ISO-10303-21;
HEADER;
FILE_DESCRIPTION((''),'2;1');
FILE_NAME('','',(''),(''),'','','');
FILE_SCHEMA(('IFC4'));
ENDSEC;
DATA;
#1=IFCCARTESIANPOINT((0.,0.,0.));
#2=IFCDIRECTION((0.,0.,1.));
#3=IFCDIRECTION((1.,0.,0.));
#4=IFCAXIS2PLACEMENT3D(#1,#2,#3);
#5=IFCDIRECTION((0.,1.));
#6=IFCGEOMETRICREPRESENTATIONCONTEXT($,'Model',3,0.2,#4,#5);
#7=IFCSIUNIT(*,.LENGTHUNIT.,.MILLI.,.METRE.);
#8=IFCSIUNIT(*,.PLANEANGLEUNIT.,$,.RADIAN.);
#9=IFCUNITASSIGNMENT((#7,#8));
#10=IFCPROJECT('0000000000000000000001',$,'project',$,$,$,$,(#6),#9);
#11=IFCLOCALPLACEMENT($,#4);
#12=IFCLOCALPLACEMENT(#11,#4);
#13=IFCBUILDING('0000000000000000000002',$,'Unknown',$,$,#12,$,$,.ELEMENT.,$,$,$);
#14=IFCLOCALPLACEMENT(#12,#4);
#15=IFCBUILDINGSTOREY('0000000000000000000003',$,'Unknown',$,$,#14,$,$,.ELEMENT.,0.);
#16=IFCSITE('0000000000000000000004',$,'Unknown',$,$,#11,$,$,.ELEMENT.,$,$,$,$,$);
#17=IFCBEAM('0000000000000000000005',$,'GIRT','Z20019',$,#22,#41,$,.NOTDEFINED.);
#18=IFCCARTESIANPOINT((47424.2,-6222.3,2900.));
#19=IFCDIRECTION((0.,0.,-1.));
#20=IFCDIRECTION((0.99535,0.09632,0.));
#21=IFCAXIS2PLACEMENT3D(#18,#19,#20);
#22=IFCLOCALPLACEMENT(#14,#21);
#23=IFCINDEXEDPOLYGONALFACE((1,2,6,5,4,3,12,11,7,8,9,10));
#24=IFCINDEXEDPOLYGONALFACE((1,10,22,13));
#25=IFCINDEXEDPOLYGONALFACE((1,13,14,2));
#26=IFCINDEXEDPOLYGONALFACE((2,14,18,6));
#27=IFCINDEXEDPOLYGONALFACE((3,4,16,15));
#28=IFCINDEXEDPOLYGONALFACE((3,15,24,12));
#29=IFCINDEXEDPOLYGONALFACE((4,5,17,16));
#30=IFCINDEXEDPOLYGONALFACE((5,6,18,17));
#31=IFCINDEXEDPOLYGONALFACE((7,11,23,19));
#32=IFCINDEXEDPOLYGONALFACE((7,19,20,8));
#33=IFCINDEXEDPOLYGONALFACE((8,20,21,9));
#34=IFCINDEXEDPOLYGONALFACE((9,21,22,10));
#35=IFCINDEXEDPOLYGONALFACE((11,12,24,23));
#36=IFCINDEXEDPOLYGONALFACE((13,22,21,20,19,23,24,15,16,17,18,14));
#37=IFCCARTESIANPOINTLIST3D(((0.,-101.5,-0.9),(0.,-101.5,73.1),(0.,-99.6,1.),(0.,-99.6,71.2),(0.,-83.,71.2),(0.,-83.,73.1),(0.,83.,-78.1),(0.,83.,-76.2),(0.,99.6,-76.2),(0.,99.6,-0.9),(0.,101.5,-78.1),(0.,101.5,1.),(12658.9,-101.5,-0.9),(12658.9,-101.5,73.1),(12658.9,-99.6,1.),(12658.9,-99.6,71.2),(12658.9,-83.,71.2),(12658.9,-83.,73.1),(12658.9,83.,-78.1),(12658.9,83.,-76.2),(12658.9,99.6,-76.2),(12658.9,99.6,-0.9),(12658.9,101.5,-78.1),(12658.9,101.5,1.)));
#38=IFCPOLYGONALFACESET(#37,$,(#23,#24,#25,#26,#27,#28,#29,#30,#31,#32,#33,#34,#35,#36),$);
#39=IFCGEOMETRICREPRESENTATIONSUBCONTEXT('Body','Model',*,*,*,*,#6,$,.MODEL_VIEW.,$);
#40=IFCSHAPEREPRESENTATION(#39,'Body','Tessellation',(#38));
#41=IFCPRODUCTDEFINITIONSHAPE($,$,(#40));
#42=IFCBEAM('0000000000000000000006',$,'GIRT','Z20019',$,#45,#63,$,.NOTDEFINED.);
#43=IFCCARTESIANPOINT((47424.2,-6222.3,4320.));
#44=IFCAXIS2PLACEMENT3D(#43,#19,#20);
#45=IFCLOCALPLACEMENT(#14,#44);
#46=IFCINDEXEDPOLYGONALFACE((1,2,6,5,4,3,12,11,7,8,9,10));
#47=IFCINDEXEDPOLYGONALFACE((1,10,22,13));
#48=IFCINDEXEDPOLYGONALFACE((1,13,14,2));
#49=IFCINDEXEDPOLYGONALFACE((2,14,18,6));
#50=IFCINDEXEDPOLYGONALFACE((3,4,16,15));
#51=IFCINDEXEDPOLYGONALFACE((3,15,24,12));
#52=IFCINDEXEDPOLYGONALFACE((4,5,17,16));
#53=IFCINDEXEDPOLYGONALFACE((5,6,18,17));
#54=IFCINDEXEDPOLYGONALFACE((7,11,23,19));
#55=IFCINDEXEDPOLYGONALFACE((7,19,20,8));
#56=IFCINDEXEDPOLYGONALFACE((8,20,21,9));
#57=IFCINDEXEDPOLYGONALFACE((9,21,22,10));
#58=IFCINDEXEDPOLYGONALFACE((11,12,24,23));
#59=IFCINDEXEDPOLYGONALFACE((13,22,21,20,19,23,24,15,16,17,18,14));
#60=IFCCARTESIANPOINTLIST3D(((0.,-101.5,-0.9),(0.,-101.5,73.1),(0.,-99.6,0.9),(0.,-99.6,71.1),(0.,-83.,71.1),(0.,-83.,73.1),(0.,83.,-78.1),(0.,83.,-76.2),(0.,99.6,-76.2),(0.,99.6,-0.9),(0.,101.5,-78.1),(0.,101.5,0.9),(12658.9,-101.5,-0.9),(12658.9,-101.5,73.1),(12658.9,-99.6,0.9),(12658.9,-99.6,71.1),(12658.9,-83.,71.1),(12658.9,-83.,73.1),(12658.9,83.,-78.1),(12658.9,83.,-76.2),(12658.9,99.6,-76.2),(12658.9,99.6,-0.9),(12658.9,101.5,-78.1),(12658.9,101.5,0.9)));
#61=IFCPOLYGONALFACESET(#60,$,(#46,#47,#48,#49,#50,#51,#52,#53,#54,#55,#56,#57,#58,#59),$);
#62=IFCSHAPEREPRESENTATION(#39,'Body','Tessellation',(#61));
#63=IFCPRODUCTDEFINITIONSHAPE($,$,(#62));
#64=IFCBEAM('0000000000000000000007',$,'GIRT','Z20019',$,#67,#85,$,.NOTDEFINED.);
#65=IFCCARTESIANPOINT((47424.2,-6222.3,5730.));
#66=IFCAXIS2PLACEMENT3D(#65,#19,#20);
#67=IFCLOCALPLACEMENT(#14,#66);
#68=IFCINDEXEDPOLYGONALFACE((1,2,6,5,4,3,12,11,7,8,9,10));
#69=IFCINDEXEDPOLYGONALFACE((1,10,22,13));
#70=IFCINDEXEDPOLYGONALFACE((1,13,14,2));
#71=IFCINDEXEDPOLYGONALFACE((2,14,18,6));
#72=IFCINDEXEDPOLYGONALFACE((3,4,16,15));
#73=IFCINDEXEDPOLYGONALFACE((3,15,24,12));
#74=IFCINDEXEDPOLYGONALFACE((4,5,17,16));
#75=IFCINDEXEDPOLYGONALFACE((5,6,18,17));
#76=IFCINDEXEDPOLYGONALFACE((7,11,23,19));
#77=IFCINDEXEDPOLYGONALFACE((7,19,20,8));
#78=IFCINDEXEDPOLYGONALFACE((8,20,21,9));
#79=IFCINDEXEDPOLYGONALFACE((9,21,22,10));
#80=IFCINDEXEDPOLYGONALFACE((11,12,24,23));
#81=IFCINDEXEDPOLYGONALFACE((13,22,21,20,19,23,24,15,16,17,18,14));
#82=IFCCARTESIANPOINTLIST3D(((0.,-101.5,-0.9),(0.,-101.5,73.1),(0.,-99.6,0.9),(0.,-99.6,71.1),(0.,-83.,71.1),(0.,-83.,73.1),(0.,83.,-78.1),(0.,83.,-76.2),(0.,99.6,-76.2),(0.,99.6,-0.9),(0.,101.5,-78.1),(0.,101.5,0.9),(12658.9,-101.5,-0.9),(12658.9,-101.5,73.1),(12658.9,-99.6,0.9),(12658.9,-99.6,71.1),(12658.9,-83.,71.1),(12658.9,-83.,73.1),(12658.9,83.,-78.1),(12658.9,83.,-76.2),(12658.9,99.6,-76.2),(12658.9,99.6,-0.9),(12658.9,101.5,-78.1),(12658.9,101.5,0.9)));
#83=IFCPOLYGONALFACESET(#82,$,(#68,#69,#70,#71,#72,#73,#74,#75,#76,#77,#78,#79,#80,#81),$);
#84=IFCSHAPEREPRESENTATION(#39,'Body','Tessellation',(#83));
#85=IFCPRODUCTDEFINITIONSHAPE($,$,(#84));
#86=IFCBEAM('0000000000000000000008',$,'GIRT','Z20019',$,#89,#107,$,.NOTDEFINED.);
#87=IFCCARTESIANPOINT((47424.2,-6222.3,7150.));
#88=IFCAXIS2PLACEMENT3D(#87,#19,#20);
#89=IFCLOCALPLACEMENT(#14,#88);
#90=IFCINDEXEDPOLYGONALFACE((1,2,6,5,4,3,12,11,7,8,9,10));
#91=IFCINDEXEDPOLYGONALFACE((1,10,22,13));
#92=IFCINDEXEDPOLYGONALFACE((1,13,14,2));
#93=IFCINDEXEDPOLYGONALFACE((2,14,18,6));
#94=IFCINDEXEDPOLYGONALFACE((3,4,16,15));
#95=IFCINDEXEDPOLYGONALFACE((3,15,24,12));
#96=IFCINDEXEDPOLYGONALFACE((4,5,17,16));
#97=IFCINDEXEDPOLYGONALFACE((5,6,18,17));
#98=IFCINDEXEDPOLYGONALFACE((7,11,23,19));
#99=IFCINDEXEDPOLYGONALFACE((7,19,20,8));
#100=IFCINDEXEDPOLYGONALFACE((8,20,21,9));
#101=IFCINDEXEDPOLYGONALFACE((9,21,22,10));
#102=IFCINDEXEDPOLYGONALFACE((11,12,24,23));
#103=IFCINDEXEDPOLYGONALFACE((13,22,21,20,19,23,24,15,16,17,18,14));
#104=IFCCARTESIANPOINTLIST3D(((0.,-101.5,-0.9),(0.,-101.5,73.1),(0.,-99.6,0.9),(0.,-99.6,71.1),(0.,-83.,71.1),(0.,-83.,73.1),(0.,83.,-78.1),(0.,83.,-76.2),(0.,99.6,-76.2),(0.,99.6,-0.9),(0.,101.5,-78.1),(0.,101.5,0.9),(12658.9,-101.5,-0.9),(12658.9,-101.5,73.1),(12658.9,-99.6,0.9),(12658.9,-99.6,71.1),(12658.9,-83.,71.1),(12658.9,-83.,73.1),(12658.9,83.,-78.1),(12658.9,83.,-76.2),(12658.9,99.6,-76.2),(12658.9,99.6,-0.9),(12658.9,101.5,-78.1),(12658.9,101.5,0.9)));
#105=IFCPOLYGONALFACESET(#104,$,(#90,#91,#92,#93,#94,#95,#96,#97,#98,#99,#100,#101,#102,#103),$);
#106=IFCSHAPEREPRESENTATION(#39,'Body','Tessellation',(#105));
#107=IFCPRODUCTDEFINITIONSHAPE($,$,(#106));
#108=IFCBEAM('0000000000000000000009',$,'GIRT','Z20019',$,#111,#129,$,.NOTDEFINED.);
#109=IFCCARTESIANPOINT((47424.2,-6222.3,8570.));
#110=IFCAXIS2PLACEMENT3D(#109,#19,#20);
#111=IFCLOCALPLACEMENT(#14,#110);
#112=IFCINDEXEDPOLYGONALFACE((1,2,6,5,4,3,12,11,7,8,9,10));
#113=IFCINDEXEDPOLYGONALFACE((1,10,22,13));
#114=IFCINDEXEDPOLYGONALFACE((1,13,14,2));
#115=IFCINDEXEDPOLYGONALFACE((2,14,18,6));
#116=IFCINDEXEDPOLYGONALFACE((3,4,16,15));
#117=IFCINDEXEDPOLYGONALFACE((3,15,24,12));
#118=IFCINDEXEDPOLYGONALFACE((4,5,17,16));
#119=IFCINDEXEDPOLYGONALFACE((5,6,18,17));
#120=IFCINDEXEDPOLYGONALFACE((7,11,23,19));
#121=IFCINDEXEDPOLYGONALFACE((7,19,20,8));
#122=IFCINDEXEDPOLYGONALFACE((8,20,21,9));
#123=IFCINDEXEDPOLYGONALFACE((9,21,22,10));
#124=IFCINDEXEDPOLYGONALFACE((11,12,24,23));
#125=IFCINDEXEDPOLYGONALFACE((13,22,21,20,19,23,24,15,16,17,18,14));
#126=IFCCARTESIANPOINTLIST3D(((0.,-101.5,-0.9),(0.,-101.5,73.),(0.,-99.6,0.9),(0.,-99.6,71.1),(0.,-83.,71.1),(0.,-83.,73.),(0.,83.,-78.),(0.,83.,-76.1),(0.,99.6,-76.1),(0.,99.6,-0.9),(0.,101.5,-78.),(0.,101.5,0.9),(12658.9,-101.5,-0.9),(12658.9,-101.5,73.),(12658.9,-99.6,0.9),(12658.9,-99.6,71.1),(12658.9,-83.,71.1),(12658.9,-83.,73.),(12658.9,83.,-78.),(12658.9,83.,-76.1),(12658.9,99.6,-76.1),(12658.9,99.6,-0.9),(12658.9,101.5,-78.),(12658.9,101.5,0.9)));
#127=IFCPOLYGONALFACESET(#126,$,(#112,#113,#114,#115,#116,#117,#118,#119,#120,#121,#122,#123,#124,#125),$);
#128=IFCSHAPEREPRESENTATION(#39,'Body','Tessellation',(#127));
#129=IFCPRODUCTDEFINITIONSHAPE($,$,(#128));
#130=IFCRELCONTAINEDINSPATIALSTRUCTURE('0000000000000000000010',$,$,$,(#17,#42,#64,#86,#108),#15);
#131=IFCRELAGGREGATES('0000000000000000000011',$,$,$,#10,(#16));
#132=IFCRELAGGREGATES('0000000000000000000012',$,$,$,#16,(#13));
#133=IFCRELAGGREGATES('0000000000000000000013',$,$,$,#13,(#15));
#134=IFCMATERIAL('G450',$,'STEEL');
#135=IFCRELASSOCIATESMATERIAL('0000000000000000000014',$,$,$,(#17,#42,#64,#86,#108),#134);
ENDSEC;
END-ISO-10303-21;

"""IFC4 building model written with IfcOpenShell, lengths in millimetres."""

from ifc_helpers import new_model, si_unit, direction, frame, origin_with_axes, place, context, subcontext, project, spatial, line, indexed_curve, outline, extrude, material, element, save


model = new_model("IFC4")

# Units and contexts
model_context = context("Model", 3, precision=0.2, world=origin_with_axes(), true_north=direction((0.0, 1.0)))
body_context = subcontext(model_context, "Body", "Model", "MODEL_VIEW")
ifc_project = project(units=[si_unit("LENGTHUNIT", "METRE", prefix="MILLI"), si_unit("PLANEANGLEUNIT", "RADIAN")], contexts=[model_context])

# Site, building, storey
site_placement = place(None, origin_with_axes())
site = spatial("IfcSite", under=ifc_project, at=site_placement, Name="Unknown", CompositionType="ELEMENT")
building_placement = place(site_placement, origin_with_axes())
building = spatial("IfcBuilding", under=site, at=building_placement, Name="Unknown", CompositionType="ELEMENT")
storey_placement = place(building_placement, origin_with_axes())
storey = spatial("IfcBuildingStorey", under=building, at=storey_placement, Name="Unknown", CompositionType="ELEMENT", Elevation=0.0)

# Shared definitions
ifc_material_1 = material(Name="G450", Category="STEEL")

# Beams
for number, where, z_axis, x_axis, name in (
    (1, (47424.2, -6222.3, 2900.0), (0.0, 0.0, -1.0), (0.99535, 0.09632, 0.0), "GIRT"),
    (2, (47424.2, -6222.3, 4320.0), (0.0, 0.0, -1.0), (0.99535, 0.09632, 0.0), "GIRT"),
    (3, (47424.2, -6222.3, 5730.0), (0.0, 0.0, -1.0), (0.99535, 0.09632, 0.0), "GIRT"),
    (4, (47424.2, -6222.3, 7150.0), (0.0, 0.0, -1.0), (0.99535, 0.09632, 0.0), "GIRT"),
    (5, (47424.2, -6222.3, 8570.0), (0.0, 0.0, -1.0), (0.99535, 0.09632, 0.0), "GIRT"),
):
    element("IfcBeam", number, at=place(storey_placement, frame(where, z_axis=z_axis, x_axis=x_axis)), inside=storey, material=ifc_material_1, Name=name, Description="Z20019", PredefinedType="NOTDEFINED", context=body_context, shape_type="SolidModel", body=[
        extrude(outline(indexed_curve([(73.0, -101.5), (73.0, -83.0), (71.2, -83.0), (71.2, -99.6), (0.9, -99.6), (0.9, 101.5), (-78.0, 101.5), (-78.0, 83.0), (-76.2, 83.0), (-76.2, 99.6), (-0.9, 99.6), (-0.9, -101.5)], segments=[line(1, 2, 3, 4, 5, 6, 7, 8, 9, 10, 11, 12, 1)])), frame((0.0, 0.0, 0.0), z_axis=(-1.0, 0.0, 0.0), x_axis=(0.0, 0.0, 1.0)), (0.0, 0.0, -1.0), 12658.9),
    ])

save(model, "model.ifc")
